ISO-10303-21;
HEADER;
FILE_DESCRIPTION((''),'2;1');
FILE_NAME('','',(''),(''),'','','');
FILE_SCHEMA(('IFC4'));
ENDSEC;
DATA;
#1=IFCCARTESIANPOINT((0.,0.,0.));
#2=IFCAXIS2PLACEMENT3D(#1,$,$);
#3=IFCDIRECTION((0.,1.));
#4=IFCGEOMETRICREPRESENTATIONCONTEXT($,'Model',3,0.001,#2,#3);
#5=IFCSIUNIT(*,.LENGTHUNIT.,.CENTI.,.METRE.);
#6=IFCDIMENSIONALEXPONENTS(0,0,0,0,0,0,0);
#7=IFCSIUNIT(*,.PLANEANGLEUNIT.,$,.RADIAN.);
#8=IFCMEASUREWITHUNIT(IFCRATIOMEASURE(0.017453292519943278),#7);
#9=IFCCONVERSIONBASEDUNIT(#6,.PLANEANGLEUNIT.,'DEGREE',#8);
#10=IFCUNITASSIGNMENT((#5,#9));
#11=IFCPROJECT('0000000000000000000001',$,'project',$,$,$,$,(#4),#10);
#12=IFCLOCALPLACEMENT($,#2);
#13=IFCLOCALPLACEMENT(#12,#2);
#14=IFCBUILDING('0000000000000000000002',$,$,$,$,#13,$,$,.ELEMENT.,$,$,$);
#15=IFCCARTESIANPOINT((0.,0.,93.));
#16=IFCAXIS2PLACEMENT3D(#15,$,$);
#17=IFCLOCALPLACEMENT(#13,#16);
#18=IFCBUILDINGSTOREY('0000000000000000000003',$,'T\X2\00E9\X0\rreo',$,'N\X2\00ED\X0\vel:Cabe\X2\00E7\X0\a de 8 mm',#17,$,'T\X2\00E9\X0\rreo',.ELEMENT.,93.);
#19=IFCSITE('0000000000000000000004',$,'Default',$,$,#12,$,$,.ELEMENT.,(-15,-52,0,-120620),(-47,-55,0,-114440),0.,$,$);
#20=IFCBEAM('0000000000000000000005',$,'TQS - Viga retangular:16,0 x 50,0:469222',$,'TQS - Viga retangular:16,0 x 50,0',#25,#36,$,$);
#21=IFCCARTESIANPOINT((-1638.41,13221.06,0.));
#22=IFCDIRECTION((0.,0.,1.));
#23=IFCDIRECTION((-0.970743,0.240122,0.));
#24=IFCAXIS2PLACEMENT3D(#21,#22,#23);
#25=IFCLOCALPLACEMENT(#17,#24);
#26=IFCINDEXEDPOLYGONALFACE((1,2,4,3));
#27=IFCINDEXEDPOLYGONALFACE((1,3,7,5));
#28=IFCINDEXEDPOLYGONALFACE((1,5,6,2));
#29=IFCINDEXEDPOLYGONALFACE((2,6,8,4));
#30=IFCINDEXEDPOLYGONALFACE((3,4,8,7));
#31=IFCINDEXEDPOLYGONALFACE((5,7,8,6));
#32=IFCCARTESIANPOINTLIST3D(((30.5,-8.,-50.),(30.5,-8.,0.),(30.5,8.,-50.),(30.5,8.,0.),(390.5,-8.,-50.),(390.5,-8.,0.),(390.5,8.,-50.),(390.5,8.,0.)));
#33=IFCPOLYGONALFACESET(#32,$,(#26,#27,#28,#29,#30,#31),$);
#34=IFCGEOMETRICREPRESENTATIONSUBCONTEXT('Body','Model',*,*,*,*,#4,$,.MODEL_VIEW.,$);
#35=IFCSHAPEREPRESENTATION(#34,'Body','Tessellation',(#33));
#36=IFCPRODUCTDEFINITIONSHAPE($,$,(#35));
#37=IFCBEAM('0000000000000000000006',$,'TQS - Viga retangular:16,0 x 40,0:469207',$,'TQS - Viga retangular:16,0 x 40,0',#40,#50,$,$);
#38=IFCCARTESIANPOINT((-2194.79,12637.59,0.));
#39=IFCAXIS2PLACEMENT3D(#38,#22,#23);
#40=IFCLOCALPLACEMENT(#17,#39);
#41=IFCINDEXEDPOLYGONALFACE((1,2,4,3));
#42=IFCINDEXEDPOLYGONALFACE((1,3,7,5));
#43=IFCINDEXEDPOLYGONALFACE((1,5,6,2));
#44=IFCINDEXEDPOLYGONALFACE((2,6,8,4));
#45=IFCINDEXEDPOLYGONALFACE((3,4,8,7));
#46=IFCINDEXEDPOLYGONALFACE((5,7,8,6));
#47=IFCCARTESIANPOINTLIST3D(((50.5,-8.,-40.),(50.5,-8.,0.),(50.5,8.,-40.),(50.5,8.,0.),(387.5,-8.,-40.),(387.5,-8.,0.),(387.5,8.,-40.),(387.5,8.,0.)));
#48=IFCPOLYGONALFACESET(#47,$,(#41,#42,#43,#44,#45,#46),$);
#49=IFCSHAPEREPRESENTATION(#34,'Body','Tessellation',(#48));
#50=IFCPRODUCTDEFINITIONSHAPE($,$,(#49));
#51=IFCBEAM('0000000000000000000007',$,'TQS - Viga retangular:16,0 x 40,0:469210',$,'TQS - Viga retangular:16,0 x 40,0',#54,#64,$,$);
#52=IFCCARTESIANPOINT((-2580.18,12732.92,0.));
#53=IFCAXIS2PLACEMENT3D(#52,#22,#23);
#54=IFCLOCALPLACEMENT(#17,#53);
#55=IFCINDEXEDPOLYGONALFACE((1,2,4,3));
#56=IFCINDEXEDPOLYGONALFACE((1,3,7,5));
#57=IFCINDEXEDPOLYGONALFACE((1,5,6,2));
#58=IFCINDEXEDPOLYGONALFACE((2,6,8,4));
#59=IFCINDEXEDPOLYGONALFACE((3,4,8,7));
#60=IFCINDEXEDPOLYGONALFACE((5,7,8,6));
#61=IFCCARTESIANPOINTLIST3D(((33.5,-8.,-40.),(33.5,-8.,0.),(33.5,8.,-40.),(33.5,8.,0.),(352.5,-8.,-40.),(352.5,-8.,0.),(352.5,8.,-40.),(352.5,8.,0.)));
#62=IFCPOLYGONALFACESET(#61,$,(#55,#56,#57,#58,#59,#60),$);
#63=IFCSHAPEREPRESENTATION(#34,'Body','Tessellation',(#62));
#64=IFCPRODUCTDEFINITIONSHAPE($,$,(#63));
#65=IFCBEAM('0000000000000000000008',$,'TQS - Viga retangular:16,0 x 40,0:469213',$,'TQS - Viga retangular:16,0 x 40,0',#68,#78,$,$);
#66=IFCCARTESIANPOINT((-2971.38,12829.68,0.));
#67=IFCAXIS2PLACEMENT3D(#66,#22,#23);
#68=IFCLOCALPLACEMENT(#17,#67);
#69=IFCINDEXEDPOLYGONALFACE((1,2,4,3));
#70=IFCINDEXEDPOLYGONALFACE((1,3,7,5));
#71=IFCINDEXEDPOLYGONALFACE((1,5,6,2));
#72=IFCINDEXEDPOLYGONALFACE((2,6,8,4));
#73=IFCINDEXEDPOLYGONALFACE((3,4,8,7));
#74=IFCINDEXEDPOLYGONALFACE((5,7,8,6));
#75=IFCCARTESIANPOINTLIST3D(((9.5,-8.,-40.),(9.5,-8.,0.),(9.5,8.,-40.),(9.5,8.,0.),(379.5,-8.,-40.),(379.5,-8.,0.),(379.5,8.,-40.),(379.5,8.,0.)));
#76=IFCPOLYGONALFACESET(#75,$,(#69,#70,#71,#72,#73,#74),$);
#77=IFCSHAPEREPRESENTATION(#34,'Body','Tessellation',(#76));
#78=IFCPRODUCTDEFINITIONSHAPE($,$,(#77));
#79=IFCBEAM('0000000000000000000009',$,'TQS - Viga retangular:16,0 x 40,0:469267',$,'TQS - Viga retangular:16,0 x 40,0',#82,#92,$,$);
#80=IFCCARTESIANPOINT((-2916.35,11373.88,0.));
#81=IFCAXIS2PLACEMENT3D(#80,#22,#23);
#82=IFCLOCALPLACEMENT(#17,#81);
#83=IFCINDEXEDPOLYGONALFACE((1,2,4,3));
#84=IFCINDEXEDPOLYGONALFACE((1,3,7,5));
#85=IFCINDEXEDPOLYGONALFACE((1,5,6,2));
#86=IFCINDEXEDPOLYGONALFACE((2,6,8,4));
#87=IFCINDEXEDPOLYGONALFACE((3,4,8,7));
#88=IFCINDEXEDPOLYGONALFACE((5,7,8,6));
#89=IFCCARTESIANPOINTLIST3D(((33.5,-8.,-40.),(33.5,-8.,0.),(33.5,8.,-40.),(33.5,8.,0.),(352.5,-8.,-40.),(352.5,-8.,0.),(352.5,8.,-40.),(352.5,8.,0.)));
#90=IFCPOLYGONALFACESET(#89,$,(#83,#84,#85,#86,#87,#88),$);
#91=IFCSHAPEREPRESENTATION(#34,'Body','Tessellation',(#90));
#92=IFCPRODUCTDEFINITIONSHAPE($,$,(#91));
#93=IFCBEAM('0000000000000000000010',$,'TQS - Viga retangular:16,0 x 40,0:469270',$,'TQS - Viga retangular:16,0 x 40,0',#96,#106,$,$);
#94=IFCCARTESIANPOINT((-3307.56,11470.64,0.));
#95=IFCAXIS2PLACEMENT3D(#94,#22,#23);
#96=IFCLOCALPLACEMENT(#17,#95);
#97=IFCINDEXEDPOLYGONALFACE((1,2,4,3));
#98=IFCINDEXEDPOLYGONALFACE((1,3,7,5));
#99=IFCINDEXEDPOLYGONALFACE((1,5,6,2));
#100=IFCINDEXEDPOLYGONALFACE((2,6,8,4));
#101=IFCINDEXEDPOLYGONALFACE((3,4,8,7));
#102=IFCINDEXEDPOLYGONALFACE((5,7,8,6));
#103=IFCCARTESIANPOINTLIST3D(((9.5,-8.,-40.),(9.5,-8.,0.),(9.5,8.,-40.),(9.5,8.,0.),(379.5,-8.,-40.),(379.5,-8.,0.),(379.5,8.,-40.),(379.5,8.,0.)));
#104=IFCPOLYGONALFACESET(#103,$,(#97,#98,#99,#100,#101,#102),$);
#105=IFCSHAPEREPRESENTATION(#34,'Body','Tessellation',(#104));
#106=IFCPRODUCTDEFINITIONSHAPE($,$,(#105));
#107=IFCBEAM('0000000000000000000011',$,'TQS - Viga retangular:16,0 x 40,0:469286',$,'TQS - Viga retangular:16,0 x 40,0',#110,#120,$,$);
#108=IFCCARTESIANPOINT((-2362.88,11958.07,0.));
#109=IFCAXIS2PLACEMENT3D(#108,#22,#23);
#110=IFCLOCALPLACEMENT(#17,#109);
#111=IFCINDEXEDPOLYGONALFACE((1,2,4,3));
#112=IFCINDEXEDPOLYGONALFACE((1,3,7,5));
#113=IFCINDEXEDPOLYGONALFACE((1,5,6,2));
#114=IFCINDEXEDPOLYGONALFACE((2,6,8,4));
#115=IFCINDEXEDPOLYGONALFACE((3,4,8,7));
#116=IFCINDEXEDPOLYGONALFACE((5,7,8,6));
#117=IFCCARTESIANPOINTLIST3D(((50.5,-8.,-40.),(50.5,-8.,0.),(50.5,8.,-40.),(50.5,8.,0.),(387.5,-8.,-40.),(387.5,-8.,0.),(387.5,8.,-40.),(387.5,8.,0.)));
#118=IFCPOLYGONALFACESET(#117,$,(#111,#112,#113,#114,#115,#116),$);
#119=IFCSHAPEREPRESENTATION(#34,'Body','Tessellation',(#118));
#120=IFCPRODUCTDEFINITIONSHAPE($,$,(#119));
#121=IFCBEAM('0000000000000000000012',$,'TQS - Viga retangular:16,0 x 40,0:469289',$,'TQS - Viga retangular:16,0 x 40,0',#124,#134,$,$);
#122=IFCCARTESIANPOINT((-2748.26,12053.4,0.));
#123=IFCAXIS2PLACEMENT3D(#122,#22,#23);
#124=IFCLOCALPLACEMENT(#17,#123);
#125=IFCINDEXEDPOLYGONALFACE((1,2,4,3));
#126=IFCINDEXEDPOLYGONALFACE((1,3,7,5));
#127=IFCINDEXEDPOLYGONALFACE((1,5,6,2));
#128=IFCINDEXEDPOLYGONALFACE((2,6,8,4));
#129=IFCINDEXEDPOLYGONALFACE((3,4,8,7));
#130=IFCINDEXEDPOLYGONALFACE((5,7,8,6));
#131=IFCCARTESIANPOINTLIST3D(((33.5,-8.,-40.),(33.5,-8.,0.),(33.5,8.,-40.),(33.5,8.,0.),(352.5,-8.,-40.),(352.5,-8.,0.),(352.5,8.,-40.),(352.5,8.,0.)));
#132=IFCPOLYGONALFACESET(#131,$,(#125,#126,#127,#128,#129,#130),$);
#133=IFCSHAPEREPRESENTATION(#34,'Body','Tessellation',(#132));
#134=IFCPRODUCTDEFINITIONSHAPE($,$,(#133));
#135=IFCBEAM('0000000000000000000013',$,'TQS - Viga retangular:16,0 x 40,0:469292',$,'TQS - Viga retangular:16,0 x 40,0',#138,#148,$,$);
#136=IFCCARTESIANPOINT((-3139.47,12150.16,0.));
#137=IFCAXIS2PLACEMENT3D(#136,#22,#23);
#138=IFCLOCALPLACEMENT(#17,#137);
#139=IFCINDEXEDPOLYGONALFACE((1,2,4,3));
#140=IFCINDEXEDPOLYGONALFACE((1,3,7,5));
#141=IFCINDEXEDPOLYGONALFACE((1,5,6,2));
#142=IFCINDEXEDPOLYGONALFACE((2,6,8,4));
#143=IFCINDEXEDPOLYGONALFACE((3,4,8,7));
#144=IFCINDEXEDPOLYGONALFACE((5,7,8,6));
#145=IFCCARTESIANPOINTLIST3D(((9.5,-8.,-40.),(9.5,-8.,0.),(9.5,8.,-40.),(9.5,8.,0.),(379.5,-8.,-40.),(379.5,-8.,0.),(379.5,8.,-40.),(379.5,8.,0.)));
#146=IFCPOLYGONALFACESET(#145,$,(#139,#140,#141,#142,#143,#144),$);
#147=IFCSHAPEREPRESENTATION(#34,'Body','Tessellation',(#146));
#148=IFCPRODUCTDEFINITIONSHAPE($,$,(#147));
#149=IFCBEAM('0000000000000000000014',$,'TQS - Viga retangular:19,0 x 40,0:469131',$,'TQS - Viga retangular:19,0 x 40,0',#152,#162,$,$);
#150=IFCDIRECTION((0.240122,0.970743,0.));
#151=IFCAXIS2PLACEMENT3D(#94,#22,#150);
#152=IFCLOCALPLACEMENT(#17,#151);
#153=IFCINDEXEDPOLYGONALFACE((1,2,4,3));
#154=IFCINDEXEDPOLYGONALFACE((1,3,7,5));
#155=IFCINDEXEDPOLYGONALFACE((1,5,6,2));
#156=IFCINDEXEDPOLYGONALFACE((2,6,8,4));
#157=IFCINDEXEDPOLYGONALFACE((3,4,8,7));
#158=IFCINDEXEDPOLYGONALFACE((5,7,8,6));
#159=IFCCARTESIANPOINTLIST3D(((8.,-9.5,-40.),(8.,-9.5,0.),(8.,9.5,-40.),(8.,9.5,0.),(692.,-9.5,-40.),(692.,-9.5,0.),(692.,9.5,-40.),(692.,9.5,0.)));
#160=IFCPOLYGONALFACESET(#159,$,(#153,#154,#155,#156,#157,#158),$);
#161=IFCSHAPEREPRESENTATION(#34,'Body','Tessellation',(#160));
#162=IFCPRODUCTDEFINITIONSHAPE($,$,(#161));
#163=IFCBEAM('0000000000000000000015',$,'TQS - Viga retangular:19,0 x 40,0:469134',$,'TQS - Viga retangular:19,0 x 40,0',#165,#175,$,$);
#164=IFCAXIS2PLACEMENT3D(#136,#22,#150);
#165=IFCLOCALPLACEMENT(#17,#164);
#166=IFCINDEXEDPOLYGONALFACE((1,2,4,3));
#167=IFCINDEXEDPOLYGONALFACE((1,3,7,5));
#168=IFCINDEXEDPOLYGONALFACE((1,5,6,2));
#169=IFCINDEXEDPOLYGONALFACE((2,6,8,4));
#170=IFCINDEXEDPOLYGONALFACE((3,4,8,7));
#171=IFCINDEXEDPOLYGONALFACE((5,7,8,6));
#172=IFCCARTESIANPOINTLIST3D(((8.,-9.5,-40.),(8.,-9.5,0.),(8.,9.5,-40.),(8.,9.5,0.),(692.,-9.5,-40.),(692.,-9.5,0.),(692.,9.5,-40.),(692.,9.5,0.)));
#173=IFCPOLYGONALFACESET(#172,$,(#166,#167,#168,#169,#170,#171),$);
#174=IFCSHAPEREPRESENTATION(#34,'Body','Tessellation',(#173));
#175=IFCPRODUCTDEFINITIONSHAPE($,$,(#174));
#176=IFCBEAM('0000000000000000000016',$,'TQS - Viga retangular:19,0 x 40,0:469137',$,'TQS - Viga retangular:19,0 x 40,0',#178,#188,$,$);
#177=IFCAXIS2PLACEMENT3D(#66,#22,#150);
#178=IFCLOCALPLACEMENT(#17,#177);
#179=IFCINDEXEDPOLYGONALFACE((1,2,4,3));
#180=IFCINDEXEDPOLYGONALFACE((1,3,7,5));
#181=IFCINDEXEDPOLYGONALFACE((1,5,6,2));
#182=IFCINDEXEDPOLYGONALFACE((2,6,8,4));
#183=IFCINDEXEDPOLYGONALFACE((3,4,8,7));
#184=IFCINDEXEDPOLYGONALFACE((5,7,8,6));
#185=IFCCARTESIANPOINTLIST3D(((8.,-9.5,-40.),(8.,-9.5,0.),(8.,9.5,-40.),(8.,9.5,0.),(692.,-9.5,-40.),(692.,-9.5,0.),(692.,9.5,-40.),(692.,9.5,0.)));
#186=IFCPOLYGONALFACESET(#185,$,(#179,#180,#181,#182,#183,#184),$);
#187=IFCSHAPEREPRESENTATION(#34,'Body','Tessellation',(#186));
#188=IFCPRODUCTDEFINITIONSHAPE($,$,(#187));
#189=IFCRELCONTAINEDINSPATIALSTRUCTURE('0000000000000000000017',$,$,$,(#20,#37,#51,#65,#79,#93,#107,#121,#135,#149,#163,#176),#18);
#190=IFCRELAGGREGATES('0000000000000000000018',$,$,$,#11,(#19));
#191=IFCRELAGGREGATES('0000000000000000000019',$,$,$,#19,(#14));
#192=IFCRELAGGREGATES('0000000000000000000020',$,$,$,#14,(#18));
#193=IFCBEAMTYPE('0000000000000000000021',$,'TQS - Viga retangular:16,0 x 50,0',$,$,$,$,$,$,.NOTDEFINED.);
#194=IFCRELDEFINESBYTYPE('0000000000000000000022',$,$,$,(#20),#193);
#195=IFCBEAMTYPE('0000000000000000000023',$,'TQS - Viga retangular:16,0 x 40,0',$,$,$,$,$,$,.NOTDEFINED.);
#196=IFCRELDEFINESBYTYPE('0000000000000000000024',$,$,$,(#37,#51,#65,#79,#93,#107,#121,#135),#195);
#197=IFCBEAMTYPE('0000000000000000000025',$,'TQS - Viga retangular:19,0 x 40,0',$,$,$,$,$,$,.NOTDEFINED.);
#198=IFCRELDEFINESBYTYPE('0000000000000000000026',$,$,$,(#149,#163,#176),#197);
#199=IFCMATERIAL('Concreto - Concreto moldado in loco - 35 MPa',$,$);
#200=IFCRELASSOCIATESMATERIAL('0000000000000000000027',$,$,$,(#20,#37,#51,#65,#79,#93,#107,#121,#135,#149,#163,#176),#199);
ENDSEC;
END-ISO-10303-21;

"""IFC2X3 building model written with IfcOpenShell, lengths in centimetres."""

from ifc_helpers import new_model, entity, si_unit, converted_unit, direction, frame, frame_2d, origin, place, context, subcontext, project, spatial, rectangle, extrude, material, type_object, element, save


model = new_model("IFC2X3")

# Units and contexts
model_context = context("Model", 3, precision=0.001, world=origin(), true_north=direction((0.0, 1.0)))
body_context = subcontext(model_context, "Body", "Model", "MODEL_VIEW")
ifc_project = project(units=[si_unit("LENGTHUNIT", "METRE", prefix="CENTI"), converted_unit("PLANEANGLEUNIT", "DEGREE", entity("IfcRatioMeasure", 0.017453292519943278), si_unit("PLANEANGLEUNIT", "RADIAN"), dimensions=[0, 0, 0, 0, 0, 0, 0])], contexts=[model_context])

# Site, building, storey
site_placement = place(None, origin())
site = spatial("IfcSite", under=ifc_project, at=site_placement, Name="Default", CompositionType="ELEMENT", RefLatitude=(-15, -52, 0, -120620), RefLongitude=(-47, -55, 0, -114440), RefElevation=0.0)
building_placement = place(site_placement, origin())
building = spatial("IfcBuilding", under=site, at=building_placement, CompositionType="ELEMENT")
storey_placement = place(building_placement, frame((0.0, 0.0, 93.0)))
storey = spatial("IfcBuildingStorey", under=building, at=storey_placement, Name="Térreo", ObjectType="Nível:Cabeça de 8 mm", LongName="Térreo", CompositionType="ELEMENT", Elevation=93.0)

# Beams
ifc_material_1 = material(Name="Concreto - Concreto moldado in loco - 35 MPa")
beam_type_1 = type_object("IfcBeamType", Name="TQS - Viga retangular:16,0 x 50,0", PredefinedType="NOTDEFINED")
beam_1_placement = place(storey_placement, frame((-1638.41, 13221.06, 0.0), z_axis=(0.0, 0.0, 1.0), x_axis=(-0.970743, 0.240122, 0.0)))
element("IfcBeam", 1, at=beam_1_placement, inside=storey, type_object=beam_type_1, material=ifc_material_1, Name="TQS - Viga retangular:16,0 x 50,0:469222", ObjectType="TQS - Viga retangular:16,0 x 50,0", context=body_context, shape_type="SweptSolid", body=[
    extrude(rectangle(XDim=50.0, YDim=16.0, at=frame_2d((0.0, 0.0), x_axis=(1.0, 0.0))), frame((30.5, 0.0, -25.0), z_axis=(1.0, 0.0, 0.0), x_axis=(0.0, 0.0, -1.0)), (0.0, 0.0, 1.0), 360.0),
])
beam_type_2 = type_object("IfcBeamType", Name="TQS - Viga retangular:16,0 x 40,0", PredefinedType="NOTDEFINED")
beam_2_placement = place(storey_placement, frame((-2194.79, 12637.59, 0.0), z_axis=(0.0, 0.0, 1.0), x_axis=(-0.970743, 0.240122, 0.0)))
element("IfcBeam", 2, at=beam_2_placement, inside=storey, type_object=beam_type_2, material=ifc_material_1, Name="TQS - Viga retangular:16,0 x 40,0:469207", ObjectType="TQS - Viga retangular:16,0 x 40,0", context=body_context, shape_type="SweptSolid", body=[
    extrude(rectangle(XDim=40.0, YDim=16.0, at=frame_2d((0.0, 0.0), x_axis=(1.0, 0.0))), frame((50.5, 0.0, -20.0), z_axis=(1.0, 0.0, 0.0), x_axis=(0.0, 0.0, -1.0)), (0.0, 0.0, 1.0), 337.0),
])
beam_3_placement = place(storey_placement, frame((-2580.18, 12732.92, 0.0), z_axis=(0.0, 0.0, 1.0), x_axis=(-0.970743, 0.240122, 0.0)))
element("IfcBeam", 3, at=beam_3_placement, inside=storey, type_object=beam_type_2, material=ifc_material_1, Name="TQS - Viga retangular:16,0 x 40,0:469210", ObjectType="TQS - Viga retangular:16,0 x 40,0", context=body_context, shape_type="SweptSolid", body=[
    extrude(rectangle(XDim=40.0, YDim=16.0, at=frame_2d((0.0, 0.0), x_axis=(1.0, 0.0))), frame((33.5, 0.0, -20.0), z_axis=(1.0, 0.0, 0.0), x_axis=(0.0, 0.0, -1.0)), (0.0, 0.0, 1.0), 319.0),
])
beam_4_placement = place(storey_placement, frame((-2971.38, 12829.68, 0.0), z_axis=(0.0, 0.0, 1.0), x_axis=(-0.970743, 0.240122, 0.0)))
element("IfcBeam", 4, at=beam_4_placement, inside=storey, type_object=beam_type_2, material=ifc_material_1, Name="TQS - Viga retangular:16,0 x 40,0:469213", ObjectType="TQS - Viga retangular:16,0 x 40,0", context=body_context, shape_type="SweptSolid", body=[
    extrude(rectangle(XDim=40.0, YDim=16.0, at=frame_2d((0.0, 0.0), x_axis=(1.0, 0.0))), frame((9.5, 0.0, -20.0), z_axis=(1.0, 0.0, 0.0), x_axis=(0.0, 0.0, -1.0)), (0.0, 0.0, 1.0), 370.0),
])
beam_5_placement = place(storey_placement, frame((-2916.35, 11373.88, 0.0), z_axis=(0.0, 0.0, 1.0), x_axis=(-0.970743, 0.240122, 0.0)))
element("IfcBeam", 5, at=beam_5_placement, inside=storey, type_object=beam_type_2, material=ifc_material_1, Name="TQS - Viga retangular:16,0 x 40,0:469267", ObjectType="TQS - Viga retangular:16,0 x 40,0", context=body_context, shape_type="SweptSolid", body=[
    extrude(rectangle(XDim=40.0, YDim=16.0, at=frame_2d((0.0, 0.0), x_axis=(1.0, 0.0))), frame((33.5, 0.0, -20.0), z_axis=(1.0, 0.0, 0.0), x_axis=(0.0, 0.0, -1.0)), (0.0, 0.0, 1.0), 319.0),
])
beam_6_placement = place(storey_placement, frame((-3307.56, 11470.64, 0.0), z_axis=(0.0, 0.0, 1.0), x_axis=(-0.970743, 0.240122, 0.0)))
element("IfcBeam", 6, at=beam_6_placement, inside=storey, type_object=beam_type_2, material=ifc_material_1, Name="TQS - Viga retangular:16,0 x 40,0:469270", ObjectType="TQS - Viga retangular:16,0 x 40,0", context=body_context, shape_type="SweptSolid", body=[
    extrude(rectangle(XDim=40.0, YDim=16.0, at=frame_2d((0.0, 0.0), x_axis=(1.0, 0.0))), frame((9.5, 0.0, -20.0), z_axis=(1.0, 0.0, 0.0), x_axis=(0.0, 0.0, -1.0)), (0.0, 0.0, 1.0), 370.0),
])
beam_7_placement = place(storey_placement, frame((-2362.88, 11958.07, 0.0), z_axis=(0.0, 0.0, 1.0), x_axis=(-0.970743, 0.240122, 0.0)))
element("IfcBeam", 7, at=beam_7_placement, inside=storey, type_object=beam_type_2, material=ifc_material_1, Name="TQS - Viga retangular:16,0 x 40,0:469286", ObjectType="TQS - Viga retangular:16,0 x 40,0", context=body_context, shape_type="SweptSolid", body=[
    extrude(rectangle(XDim=40.0, YDim=16.0, at=frame_2d((0.0, 0.0), x_axis=(1.0, 0.0))), frame((50.5, 0.0, -20.0), z_axis=(1.0, 0.0, 0.0), x_axis=(0.0, 0.0, -1.0)), (0.0, 0.0, 1.0), 337.0),
])
beam_8_placement = place(storey_placement, frame((-2748.26, 12053.4, 0.0), z_axis=(0.0, 0.0, 1.0), x_axis=(-0.970743, 0.240122, 0.0)))
element("IfcBeam", 8, at=beam_8_placement, inside=storey, type_object=beam_type_2, material=ifc_material_1, Name="TQS - Viga retangular:16,0 x 40,0:469289", ObjectType="TQS - Viga retangular:16,0 x 40,0", context=body_context, shape_type="SweptSolid", body=[
    extrude(rectangle(XDim=40.0, YDim=16.0, at=frame_2d((0.0, 0.0), x_axis=(1.0, 0.0))), frame((33.5, 0.0, -20.0), z_axis=(1.0, 0.0, 0.0), x_axis=(0.0, 0.0, -1.0)), (0.0, 0.0, 1.0), 319.0),
])
beam_9_placement = place(storey_placement, frame((-3139.47, 12150.16, 0.0), z_axis=(0.0, 0.0, 1.0), x_axis=(-0.970743, 0.240122, 0.0)))
element("IfcBeam", 9, at=beam_9_placement, inside=storey, type_object=beam_type_2, material=ifc_material_1, Name="TQS - Viga retangular:16,0 x 40,0:469292", ObjectType="TQS - Viga retangular:16,0 x 40,0", context=body_context, shape_type="SweptSolid", body=[
    extrude(rectangle(XDim=40.0, YDim=16.0, at=frame_2d((0.0, 0.0), x_axis=(1.0, 0.0))), frame((9.5, 0.0, -20.0), z_axis=(1.0, 0.0, 0.0), x_axis=(0.0, 0.0, -1.0)), (0.0, 0.0, 1.0), 370.0),
])
beam_type_3 = type_object("IfcBeamType", Name="TQS - Viga retangular:19,0 x 40,0", PredefinedType="NOTDEFINED")
beam_10_placement = place(storey_placement, frame((-3307.56, 11470.64, 0.0), z_axis=(0.0, 0.0, 1.0), x_axis=(0.240122, 0.970743, 0.0)))
element("IfcBeam", 10, at=beam_10_placement, inside=storey, type_object=beam_type_3, material=ifc_material_1, Name="TQS - Viga retangular:19,0 x 40,0:469131", ObjectType="TQS - Viga retangular:19,0 x 40,0", context=body_context, shape_type="SweptSolid", body=[
    extrude(rectangle(XDim=40.0, YDim=19.0, at=frame_2d((0.0, 0.0), x_axis=(1.0, 0.0))), frame((8.0, 0.0, -20.0), z_axis=(1.0, 0.0, 0.0), x_axis=(0.0, 0.0, -1.0)), (0.0, 0.0, 1.0), 684.0),
])
beam_11_placement = place(storey_placement, frame((-3139.47, 12150.16, 0.0), z_axis=(0.0, 0.0, 1.0), x_axis=(0.240122, 0.970743, 0.0)))
element("IfcBeam", 11, at=beam_11_placement, inside=storey, type_object=beam_type_3, material=ifc_material_1, Name="TQS - Viga retangular:19,0 x 40,0:469134", ObjectType="TQS - Viga retangular:19,0 x 40,0", context=body_context, shape_type="SweptSolid", body=[
    extrude(rectangle(XDim=40.0, YDim=19.0, at=frame_2d((0.0, 0.0), x_axis=(1.0, 0.0))), frame((8.0, 0.0, -20.0), z_axis=(1.0, 0.0, 0.0), x_axis=(0.0, 0.0, -1.0)), (0.0, 0.0, 1.0), 684.0),
])
beam_12_placement = place(storey_placement, frame((-2971.38, 12829.68, 0.0), z_axis=(0.0, 0.0, 1.0), x_axis=(0.240122, 0.970743, 0.0)))
element("IfcBeam", 12, at=beam_12_placement, inside=storey, type_object=beam_type_3, material=ifc_material_1, Name="TQS - Viga retangular:19,0 x 40,0:469137", ObjectType="TQS - Viga retangular:19,0 x 40,0", context=body_context, shape_type="SweptSolid", body=[
    extrude(rectangle(XDim=40.0, YDim=19.0, at=frame_2d((0.0, 0.0), x_axis=(1.0, 0.0))), frame((8.0, 0.0, -20.0), z_axis=(1.0, 0.0, 0.0), x_axis=(0.0, 0.0, -1.0)), (0.0, 0.0, 1.0), 684.0),
])

save(model, "model.ifc")
